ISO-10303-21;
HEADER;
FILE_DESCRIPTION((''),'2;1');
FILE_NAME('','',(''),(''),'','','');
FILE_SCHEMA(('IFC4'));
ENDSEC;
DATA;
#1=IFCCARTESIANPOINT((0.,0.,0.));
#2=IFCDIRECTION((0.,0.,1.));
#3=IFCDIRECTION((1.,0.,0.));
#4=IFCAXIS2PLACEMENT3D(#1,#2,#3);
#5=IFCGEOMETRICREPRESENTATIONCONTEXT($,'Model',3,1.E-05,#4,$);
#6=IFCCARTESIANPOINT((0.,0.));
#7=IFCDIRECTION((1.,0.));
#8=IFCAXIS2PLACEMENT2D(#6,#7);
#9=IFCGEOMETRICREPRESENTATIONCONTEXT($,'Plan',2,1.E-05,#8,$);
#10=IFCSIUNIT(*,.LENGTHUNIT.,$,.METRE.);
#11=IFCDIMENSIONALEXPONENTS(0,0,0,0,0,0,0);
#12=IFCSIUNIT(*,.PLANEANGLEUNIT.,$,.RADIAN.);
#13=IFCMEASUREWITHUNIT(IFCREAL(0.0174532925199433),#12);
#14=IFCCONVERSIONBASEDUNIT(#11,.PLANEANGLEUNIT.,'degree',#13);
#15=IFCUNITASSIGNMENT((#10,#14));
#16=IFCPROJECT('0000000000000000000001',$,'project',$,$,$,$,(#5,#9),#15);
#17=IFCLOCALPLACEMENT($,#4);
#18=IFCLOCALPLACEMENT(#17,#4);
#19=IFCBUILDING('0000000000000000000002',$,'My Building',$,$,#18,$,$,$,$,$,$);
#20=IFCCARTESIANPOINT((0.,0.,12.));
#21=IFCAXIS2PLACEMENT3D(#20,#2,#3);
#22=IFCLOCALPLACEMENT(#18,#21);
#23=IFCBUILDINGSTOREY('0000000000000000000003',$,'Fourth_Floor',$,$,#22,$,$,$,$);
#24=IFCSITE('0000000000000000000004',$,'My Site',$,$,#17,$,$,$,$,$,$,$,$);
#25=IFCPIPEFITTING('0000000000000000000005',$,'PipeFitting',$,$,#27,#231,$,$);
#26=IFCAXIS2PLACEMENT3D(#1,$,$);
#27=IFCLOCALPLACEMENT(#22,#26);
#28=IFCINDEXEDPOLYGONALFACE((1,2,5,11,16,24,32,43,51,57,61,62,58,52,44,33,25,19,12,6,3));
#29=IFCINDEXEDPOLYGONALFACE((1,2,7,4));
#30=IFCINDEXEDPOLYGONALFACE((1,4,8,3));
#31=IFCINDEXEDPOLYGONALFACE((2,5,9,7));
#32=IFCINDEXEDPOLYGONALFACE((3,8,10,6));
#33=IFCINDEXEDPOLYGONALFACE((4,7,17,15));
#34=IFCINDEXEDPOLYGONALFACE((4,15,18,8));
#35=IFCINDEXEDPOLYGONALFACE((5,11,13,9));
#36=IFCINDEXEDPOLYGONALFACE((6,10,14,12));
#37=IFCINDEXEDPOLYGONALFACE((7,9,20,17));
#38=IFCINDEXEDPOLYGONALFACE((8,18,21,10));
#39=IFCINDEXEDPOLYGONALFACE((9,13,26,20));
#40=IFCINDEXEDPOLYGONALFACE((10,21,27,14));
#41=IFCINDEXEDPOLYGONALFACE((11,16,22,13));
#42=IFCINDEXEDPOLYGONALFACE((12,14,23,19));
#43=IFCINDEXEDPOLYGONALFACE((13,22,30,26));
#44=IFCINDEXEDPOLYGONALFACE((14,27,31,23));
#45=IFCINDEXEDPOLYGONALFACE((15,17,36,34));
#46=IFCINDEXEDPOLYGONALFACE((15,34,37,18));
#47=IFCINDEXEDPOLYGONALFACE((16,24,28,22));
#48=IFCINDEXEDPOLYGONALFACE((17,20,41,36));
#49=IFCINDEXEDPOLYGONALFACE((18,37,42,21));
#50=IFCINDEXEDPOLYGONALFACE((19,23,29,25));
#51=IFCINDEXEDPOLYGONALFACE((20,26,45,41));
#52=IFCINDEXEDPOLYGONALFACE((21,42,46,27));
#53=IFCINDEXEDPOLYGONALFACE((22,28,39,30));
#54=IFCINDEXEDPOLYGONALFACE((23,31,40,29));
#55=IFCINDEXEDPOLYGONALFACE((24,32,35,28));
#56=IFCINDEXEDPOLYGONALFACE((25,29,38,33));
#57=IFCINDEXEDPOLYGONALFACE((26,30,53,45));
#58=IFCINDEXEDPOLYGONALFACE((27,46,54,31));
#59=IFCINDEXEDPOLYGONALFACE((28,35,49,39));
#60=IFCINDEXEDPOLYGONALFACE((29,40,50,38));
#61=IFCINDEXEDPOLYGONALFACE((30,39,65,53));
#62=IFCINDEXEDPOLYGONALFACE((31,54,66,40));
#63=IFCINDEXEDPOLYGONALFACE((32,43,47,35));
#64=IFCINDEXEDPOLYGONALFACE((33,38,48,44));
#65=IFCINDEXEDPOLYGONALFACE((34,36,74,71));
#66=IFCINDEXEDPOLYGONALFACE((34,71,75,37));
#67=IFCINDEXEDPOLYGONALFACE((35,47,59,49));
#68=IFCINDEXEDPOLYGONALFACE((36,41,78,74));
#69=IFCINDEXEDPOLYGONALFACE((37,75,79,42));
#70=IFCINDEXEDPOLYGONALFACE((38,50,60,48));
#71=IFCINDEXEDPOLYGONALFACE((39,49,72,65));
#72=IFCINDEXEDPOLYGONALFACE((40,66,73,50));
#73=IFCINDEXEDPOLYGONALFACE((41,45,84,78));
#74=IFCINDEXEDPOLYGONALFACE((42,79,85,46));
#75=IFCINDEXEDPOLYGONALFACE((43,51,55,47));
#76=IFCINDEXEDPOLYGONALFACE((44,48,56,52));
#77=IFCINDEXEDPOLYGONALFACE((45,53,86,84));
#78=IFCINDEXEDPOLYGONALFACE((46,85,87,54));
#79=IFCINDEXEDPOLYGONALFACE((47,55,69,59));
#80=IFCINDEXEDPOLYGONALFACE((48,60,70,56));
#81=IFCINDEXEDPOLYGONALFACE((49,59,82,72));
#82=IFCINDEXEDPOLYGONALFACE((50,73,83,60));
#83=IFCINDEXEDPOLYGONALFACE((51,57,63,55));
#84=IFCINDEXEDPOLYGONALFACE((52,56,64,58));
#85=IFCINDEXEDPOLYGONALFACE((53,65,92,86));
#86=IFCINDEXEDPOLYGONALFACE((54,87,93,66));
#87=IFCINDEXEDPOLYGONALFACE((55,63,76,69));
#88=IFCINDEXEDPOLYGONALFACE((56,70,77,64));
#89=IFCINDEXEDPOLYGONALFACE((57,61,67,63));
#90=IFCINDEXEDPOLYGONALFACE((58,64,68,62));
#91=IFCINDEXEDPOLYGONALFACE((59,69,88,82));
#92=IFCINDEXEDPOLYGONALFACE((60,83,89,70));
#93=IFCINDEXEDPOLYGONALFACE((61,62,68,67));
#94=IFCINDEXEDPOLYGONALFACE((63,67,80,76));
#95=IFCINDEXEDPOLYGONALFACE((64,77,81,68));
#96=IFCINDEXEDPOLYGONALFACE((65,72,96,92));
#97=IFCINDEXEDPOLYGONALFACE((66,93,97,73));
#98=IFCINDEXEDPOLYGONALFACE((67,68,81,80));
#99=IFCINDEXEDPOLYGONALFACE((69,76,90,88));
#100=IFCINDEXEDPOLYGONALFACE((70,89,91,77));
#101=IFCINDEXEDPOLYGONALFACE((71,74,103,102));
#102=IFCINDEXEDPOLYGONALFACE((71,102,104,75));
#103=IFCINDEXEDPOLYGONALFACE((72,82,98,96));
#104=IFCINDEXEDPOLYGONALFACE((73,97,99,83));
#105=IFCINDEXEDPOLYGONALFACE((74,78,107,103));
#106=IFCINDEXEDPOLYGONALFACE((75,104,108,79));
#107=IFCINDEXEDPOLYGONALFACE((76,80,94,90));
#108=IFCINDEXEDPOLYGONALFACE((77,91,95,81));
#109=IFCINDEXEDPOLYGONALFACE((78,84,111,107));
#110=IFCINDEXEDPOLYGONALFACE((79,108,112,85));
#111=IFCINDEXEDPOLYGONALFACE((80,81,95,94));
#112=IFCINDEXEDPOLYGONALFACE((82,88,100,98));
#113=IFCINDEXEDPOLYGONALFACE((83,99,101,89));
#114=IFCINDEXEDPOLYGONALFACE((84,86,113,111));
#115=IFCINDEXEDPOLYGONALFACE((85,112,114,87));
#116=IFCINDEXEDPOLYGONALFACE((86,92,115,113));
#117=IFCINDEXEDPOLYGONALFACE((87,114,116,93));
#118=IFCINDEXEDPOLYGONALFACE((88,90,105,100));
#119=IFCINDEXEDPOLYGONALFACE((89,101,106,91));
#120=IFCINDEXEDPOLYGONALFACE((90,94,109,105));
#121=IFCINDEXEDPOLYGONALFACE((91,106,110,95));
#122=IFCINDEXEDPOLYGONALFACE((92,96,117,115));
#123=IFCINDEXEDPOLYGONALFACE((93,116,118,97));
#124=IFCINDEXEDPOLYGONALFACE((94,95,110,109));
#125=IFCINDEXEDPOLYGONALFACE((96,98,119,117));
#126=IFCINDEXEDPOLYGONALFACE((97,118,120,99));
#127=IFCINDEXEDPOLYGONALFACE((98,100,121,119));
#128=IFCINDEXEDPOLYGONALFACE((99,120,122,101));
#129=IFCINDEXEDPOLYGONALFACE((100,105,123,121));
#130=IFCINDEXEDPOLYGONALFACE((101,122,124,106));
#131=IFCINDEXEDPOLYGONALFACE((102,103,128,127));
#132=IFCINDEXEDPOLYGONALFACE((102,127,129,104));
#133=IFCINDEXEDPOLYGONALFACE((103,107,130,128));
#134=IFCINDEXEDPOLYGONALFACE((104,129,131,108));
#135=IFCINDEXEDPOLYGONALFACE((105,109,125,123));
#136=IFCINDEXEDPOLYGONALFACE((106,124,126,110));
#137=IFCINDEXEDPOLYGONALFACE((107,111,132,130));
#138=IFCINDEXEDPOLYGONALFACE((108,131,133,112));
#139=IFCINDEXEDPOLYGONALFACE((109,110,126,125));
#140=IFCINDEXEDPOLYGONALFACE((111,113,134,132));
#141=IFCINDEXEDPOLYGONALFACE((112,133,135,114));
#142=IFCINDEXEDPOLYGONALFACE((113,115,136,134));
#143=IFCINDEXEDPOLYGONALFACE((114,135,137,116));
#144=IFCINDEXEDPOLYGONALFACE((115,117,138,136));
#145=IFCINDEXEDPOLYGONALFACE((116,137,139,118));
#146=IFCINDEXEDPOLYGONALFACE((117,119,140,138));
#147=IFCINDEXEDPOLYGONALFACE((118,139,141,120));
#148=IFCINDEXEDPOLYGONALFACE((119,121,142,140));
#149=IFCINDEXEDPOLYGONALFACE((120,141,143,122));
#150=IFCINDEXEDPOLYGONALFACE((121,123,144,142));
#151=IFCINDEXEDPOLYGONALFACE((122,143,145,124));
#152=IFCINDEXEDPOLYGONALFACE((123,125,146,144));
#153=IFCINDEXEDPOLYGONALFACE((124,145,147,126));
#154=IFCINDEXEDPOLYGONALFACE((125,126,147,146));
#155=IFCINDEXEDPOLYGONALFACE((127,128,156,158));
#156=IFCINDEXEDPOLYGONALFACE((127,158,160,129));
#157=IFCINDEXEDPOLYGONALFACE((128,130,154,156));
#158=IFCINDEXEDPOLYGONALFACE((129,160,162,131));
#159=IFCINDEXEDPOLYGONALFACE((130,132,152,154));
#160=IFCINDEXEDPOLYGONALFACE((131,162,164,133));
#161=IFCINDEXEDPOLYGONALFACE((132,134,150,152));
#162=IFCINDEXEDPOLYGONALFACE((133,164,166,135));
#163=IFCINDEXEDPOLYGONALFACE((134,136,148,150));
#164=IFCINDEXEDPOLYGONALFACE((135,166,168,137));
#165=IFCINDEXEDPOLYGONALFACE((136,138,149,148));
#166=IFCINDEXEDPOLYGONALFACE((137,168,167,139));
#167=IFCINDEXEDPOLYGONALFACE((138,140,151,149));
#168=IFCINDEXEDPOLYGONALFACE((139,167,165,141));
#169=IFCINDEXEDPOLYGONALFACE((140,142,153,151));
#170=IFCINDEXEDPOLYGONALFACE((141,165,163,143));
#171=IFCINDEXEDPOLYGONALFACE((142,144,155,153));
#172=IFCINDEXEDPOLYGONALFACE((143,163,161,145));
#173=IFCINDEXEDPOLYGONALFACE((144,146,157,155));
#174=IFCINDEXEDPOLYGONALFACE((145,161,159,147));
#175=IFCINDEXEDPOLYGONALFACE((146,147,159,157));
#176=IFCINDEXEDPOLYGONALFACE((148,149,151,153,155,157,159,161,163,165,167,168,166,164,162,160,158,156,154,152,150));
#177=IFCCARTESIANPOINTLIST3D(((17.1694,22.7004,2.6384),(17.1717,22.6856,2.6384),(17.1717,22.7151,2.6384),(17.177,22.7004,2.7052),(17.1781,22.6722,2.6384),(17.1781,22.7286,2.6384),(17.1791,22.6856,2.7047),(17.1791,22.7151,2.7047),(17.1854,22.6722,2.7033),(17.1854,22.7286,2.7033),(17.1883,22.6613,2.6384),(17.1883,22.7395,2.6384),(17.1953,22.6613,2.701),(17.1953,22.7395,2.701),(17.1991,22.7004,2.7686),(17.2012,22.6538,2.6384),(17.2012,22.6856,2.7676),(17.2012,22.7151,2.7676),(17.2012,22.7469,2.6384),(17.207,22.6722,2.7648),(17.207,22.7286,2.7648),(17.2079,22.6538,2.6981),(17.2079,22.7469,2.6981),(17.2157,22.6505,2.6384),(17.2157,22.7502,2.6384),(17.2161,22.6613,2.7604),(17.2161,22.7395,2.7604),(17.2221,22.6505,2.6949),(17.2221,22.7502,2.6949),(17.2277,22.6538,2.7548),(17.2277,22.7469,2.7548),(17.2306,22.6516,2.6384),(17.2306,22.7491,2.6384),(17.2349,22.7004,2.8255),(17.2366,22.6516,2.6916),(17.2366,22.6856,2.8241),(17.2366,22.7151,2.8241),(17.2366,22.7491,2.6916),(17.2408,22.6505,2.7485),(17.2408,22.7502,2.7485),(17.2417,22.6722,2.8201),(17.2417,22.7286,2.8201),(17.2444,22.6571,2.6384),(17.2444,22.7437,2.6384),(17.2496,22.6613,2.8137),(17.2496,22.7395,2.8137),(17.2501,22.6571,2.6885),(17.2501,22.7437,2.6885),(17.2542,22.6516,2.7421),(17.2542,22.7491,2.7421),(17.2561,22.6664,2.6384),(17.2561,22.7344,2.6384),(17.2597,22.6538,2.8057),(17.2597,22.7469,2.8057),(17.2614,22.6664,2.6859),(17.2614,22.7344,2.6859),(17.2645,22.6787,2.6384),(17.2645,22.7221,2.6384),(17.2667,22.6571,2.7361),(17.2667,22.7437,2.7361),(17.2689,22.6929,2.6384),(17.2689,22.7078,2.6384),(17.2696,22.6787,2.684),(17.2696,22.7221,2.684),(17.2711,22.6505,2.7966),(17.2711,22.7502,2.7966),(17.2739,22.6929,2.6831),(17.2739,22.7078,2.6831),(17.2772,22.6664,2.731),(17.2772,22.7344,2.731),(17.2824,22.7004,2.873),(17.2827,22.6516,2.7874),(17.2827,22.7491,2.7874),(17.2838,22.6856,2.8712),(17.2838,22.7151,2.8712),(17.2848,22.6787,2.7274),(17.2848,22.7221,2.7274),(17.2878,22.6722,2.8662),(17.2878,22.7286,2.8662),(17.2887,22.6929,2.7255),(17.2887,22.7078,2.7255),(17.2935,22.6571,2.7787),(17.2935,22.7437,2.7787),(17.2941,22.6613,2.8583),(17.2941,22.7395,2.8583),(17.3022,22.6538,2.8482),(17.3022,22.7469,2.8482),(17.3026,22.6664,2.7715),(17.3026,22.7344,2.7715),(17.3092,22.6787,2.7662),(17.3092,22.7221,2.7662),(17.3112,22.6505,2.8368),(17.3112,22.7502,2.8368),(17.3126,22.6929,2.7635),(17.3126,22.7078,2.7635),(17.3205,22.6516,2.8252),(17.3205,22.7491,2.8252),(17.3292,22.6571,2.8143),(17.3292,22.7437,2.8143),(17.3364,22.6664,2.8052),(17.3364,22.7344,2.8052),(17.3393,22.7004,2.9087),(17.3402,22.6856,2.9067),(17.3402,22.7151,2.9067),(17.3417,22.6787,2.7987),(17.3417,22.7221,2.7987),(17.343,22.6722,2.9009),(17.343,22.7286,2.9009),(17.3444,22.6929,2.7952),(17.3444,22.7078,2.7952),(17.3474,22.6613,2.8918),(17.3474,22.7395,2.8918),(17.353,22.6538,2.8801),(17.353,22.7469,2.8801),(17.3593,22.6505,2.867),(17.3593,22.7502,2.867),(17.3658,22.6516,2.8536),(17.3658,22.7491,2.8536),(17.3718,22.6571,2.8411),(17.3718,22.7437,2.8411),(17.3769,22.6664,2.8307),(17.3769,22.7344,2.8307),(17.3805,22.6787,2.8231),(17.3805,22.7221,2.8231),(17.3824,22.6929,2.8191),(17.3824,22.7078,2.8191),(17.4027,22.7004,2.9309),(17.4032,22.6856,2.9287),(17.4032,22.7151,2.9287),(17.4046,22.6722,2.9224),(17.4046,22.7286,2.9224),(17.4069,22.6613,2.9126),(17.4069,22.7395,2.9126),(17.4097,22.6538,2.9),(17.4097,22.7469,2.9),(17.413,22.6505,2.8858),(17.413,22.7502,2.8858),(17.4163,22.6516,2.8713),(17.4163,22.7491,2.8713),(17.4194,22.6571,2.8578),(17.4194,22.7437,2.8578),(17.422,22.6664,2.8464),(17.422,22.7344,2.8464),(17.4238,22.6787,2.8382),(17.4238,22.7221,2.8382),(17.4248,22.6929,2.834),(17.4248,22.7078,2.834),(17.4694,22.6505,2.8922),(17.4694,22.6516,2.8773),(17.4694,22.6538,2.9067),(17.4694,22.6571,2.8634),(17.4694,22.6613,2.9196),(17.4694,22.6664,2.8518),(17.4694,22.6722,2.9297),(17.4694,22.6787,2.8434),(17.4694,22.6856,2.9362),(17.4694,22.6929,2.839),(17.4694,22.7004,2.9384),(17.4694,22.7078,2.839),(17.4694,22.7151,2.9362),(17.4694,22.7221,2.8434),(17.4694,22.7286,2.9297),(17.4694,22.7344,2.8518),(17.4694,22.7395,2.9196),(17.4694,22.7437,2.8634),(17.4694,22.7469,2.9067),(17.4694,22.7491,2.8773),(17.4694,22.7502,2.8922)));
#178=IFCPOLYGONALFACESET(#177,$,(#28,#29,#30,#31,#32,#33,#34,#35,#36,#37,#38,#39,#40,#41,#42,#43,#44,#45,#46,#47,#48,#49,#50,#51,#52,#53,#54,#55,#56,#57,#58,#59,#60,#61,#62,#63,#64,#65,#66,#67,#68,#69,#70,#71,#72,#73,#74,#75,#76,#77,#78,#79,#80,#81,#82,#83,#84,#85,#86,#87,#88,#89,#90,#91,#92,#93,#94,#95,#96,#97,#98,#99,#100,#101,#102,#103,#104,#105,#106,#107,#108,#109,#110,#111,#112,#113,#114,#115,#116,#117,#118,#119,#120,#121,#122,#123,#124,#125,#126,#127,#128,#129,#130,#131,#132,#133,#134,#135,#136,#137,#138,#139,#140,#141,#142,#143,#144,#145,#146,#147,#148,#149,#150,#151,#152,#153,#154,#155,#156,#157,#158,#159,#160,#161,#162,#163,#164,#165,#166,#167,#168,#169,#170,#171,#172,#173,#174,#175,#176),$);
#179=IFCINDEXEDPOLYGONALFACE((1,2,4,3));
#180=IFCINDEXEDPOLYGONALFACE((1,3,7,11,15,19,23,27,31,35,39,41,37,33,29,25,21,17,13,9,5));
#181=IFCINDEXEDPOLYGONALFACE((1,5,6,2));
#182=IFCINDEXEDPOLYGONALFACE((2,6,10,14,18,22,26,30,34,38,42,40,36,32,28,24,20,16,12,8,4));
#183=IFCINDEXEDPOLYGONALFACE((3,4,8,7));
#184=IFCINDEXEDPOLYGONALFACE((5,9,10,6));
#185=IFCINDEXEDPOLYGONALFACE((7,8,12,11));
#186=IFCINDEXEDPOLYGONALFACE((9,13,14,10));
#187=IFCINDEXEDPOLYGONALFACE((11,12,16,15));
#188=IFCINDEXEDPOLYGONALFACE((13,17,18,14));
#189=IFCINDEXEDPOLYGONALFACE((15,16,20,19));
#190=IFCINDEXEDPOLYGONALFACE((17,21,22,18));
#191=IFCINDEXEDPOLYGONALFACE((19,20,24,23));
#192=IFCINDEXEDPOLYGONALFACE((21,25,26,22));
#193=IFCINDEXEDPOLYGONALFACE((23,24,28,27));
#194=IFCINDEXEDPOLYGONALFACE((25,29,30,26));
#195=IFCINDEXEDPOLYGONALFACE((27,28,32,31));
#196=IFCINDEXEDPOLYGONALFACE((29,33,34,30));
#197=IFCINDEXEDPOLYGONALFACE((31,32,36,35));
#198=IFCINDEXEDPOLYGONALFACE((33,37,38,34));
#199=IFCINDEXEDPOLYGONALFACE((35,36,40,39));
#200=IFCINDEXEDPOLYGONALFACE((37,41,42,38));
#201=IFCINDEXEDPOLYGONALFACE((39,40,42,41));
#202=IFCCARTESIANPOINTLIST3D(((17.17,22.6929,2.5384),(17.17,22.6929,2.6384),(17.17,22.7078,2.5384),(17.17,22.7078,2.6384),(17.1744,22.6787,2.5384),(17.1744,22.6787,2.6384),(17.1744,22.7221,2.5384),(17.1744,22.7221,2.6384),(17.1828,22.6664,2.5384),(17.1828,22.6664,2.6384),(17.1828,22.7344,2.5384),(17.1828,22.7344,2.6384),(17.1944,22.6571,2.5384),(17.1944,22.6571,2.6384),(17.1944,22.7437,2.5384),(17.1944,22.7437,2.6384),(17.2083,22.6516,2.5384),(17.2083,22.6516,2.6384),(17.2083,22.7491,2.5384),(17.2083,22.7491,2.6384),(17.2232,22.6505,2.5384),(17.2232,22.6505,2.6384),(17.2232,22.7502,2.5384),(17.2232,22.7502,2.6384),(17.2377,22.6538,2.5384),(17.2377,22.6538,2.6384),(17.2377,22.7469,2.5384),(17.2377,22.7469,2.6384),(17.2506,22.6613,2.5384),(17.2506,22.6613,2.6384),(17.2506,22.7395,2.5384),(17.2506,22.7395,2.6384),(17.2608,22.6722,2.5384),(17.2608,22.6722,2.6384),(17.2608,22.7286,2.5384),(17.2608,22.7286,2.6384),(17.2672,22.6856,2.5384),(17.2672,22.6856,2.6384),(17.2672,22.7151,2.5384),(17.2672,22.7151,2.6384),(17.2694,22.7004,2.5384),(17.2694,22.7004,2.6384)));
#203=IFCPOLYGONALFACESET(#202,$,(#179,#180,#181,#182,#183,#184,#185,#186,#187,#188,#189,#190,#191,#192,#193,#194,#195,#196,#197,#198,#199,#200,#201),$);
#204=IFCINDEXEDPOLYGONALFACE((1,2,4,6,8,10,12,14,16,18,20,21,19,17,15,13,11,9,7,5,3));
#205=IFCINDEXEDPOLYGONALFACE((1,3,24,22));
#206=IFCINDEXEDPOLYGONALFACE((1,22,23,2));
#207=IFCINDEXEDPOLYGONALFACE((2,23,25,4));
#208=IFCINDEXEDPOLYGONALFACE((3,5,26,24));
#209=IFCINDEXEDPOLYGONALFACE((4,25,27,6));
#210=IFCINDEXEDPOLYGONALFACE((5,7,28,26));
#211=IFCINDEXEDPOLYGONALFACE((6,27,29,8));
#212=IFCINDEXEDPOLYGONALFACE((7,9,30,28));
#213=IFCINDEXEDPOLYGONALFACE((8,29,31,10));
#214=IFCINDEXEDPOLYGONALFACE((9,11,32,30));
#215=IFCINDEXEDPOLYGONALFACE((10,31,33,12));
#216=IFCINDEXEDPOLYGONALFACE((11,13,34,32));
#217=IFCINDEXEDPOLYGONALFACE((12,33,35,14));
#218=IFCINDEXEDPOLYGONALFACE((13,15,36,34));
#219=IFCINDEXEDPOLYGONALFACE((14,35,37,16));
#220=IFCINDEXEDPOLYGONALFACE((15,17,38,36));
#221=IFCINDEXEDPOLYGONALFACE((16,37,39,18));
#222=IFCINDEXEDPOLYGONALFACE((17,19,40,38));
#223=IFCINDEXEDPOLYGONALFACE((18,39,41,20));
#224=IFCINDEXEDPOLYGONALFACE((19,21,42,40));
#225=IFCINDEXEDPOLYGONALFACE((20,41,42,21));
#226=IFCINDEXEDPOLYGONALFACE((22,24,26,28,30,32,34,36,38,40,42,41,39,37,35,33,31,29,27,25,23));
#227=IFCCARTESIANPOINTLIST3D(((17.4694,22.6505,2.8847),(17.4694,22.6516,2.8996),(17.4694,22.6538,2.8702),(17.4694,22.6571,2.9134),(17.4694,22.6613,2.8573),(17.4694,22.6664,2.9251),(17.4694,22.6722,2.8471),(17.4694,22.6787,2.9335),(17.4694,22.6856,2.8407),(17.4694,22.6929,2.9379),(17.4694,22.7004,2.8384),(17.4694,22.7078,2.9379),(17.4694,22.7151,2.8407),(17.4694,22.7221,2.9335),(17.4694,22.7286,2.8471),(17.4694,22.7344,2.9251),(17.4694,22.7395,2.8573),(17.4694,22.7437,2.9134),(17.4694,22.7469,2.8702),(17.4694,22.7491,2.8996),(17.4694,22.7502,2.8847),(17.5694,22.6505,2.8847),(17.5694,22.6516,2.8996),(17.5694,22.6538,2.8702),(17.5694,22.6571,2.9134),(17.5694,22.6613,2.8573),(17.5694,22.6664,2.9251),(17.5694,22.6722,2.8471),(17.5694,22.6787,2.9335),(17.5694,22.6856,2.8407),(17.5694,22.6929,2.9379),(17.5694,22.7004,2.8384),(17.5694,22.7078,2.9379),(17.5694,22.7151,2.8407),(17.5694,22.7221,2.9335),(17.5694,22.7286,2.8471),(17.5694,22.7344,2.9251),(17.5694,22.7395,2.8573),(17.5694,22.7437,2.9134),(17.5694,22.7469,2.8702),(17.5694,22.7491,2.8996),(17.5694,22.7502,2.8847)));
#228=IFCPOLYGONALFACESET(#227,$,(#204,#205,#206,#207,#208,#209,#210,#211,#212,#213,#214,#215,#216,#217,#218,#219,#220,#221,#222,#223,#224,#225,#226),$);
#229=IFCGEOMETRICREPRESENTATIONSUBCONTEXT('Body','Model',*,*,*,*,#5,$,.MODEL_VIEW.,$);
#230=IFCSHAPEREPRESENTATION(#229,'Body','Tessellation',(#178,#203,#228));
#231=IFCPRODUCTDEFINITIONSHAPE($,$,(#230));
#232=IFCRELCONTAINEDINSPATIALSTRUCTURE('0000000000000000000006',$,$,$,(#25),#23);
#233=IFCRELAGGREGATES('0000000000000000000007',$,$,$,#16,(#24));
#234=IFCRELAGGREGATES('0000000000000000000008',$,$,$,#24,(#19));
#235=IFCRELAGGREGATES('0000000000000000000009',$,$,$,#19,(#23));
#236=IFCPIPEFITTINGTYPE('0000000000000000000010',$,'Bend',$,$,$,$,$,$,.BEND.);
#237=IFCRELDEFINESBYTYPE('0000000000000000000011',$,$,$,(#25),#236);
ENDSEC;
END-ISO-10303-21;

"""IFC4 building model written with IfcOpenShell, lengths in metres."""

from ifc_helpers import new_model, entity, si_unit, converted_unit, frame, origin_with_axes, origin_2d_with_axis, place, context, subcontext, project, spatial, circle, extrude, source, transform, mapped, type_object, type_shapes, element, save


model = new_model("IFC4")

# Units and contexts
model_context = context("Model", 3, precision=1e-05, world=origin_with_axes())
plan_context = context("Plan", 2, precision=1e-05, world=origin_2d_with_axis())
body_context = subcontext(model_context, "Body", "Model", "MODEL_VIEW")
ifc_project = project(units=[si_unit("LENGTHUNIT", "METRE"), converted_unit("PLANEANGLEUNIT", "degree", entity("IfcReal", 0.0174532925199433), si_unit("PLANEANGLEUNIT", "RADIAN"), dimensions=[0, 0, 0, 0, 0, 0, 0])], contexts=[model_context, plan_context])

# Site, building, storey
site_placement = place(None, origin_with_axes())
site = spatial("IfcSite", under=ifc_project, at=site_placement, Name="My Site")
building_placement = place(site_placement, origin_with_axes())
building = spatial("IfcBuilding", under=site, at=building_placement, Name="My Building")
storey_placement = place(building_placement, frame((0.0, 0.0, 12.0), z_axis=(0.0, 0.0, 1.0), x_axis=(1.0, 0.0, 0.0)))
storey = spatial("IfcBuildingStorey", under=building, at=storey_placement, Name="Fourth_Floor")

# Pipe fitting
pipe_fitting_type = type_object("IfcPipeFittingType", Name="Bend", PredefinedType="BEND")
shared_shape = source(origin_with_axes(), body_context, "Body", "SolidModel", [
    entity("IfcSweptDiskSolid", entity("IfcIndexedPolyCurve", entity("IfcCartesianPointList3D", [[0.0, 0.0, -0.1], [0.0732, 0.0, -0.2768], [0.25, 0.0, -0.35]]), [entity("IfcArcIndex", [1, 2, 3])]), 0.05),
    extrude(circle(Radius=0.05), origin_with_axes(), (0.0, 0.0, -1.0), 0.1),
    extrude(circle(Radius=0.05), frame((0.25, 0.0, -0.35), z_axis=(1.0, 0.0, 0.0), x_axis=(0.0, 0.0, 1.0)), (0.0, 0.0, 1.0), 0.1),
])
type_shapes(pipe_fitting_type, [shared_shape])
for number, where, z_axis, x_axis, name in (
    (1, (17.2194, 22.7004, 2.5384), (0.0, 0.0, -1.0), (1.0, 0.000001, 0.0), "PipeFitting"),
):
    element("IfcPipeFitting", number, at=place(storey_placement, frame(where, z_axis=z_axis, x_axis=x_axis)), inside=storey, type_object=pipe_fitting_type, Name=name, context=body_context, shape_type="MappedRepresentation", body=[
        mapped(shared_shape, transform((0.0, 0.0, 0.0), x_axis=(1.0, 0.0, 0.0), y_axis=(0.0, 1.0, 0.0), z_axis=(0.0, 0.0, 1.0), scale=1.0)),
    ])

save(model, "model.ifc")
